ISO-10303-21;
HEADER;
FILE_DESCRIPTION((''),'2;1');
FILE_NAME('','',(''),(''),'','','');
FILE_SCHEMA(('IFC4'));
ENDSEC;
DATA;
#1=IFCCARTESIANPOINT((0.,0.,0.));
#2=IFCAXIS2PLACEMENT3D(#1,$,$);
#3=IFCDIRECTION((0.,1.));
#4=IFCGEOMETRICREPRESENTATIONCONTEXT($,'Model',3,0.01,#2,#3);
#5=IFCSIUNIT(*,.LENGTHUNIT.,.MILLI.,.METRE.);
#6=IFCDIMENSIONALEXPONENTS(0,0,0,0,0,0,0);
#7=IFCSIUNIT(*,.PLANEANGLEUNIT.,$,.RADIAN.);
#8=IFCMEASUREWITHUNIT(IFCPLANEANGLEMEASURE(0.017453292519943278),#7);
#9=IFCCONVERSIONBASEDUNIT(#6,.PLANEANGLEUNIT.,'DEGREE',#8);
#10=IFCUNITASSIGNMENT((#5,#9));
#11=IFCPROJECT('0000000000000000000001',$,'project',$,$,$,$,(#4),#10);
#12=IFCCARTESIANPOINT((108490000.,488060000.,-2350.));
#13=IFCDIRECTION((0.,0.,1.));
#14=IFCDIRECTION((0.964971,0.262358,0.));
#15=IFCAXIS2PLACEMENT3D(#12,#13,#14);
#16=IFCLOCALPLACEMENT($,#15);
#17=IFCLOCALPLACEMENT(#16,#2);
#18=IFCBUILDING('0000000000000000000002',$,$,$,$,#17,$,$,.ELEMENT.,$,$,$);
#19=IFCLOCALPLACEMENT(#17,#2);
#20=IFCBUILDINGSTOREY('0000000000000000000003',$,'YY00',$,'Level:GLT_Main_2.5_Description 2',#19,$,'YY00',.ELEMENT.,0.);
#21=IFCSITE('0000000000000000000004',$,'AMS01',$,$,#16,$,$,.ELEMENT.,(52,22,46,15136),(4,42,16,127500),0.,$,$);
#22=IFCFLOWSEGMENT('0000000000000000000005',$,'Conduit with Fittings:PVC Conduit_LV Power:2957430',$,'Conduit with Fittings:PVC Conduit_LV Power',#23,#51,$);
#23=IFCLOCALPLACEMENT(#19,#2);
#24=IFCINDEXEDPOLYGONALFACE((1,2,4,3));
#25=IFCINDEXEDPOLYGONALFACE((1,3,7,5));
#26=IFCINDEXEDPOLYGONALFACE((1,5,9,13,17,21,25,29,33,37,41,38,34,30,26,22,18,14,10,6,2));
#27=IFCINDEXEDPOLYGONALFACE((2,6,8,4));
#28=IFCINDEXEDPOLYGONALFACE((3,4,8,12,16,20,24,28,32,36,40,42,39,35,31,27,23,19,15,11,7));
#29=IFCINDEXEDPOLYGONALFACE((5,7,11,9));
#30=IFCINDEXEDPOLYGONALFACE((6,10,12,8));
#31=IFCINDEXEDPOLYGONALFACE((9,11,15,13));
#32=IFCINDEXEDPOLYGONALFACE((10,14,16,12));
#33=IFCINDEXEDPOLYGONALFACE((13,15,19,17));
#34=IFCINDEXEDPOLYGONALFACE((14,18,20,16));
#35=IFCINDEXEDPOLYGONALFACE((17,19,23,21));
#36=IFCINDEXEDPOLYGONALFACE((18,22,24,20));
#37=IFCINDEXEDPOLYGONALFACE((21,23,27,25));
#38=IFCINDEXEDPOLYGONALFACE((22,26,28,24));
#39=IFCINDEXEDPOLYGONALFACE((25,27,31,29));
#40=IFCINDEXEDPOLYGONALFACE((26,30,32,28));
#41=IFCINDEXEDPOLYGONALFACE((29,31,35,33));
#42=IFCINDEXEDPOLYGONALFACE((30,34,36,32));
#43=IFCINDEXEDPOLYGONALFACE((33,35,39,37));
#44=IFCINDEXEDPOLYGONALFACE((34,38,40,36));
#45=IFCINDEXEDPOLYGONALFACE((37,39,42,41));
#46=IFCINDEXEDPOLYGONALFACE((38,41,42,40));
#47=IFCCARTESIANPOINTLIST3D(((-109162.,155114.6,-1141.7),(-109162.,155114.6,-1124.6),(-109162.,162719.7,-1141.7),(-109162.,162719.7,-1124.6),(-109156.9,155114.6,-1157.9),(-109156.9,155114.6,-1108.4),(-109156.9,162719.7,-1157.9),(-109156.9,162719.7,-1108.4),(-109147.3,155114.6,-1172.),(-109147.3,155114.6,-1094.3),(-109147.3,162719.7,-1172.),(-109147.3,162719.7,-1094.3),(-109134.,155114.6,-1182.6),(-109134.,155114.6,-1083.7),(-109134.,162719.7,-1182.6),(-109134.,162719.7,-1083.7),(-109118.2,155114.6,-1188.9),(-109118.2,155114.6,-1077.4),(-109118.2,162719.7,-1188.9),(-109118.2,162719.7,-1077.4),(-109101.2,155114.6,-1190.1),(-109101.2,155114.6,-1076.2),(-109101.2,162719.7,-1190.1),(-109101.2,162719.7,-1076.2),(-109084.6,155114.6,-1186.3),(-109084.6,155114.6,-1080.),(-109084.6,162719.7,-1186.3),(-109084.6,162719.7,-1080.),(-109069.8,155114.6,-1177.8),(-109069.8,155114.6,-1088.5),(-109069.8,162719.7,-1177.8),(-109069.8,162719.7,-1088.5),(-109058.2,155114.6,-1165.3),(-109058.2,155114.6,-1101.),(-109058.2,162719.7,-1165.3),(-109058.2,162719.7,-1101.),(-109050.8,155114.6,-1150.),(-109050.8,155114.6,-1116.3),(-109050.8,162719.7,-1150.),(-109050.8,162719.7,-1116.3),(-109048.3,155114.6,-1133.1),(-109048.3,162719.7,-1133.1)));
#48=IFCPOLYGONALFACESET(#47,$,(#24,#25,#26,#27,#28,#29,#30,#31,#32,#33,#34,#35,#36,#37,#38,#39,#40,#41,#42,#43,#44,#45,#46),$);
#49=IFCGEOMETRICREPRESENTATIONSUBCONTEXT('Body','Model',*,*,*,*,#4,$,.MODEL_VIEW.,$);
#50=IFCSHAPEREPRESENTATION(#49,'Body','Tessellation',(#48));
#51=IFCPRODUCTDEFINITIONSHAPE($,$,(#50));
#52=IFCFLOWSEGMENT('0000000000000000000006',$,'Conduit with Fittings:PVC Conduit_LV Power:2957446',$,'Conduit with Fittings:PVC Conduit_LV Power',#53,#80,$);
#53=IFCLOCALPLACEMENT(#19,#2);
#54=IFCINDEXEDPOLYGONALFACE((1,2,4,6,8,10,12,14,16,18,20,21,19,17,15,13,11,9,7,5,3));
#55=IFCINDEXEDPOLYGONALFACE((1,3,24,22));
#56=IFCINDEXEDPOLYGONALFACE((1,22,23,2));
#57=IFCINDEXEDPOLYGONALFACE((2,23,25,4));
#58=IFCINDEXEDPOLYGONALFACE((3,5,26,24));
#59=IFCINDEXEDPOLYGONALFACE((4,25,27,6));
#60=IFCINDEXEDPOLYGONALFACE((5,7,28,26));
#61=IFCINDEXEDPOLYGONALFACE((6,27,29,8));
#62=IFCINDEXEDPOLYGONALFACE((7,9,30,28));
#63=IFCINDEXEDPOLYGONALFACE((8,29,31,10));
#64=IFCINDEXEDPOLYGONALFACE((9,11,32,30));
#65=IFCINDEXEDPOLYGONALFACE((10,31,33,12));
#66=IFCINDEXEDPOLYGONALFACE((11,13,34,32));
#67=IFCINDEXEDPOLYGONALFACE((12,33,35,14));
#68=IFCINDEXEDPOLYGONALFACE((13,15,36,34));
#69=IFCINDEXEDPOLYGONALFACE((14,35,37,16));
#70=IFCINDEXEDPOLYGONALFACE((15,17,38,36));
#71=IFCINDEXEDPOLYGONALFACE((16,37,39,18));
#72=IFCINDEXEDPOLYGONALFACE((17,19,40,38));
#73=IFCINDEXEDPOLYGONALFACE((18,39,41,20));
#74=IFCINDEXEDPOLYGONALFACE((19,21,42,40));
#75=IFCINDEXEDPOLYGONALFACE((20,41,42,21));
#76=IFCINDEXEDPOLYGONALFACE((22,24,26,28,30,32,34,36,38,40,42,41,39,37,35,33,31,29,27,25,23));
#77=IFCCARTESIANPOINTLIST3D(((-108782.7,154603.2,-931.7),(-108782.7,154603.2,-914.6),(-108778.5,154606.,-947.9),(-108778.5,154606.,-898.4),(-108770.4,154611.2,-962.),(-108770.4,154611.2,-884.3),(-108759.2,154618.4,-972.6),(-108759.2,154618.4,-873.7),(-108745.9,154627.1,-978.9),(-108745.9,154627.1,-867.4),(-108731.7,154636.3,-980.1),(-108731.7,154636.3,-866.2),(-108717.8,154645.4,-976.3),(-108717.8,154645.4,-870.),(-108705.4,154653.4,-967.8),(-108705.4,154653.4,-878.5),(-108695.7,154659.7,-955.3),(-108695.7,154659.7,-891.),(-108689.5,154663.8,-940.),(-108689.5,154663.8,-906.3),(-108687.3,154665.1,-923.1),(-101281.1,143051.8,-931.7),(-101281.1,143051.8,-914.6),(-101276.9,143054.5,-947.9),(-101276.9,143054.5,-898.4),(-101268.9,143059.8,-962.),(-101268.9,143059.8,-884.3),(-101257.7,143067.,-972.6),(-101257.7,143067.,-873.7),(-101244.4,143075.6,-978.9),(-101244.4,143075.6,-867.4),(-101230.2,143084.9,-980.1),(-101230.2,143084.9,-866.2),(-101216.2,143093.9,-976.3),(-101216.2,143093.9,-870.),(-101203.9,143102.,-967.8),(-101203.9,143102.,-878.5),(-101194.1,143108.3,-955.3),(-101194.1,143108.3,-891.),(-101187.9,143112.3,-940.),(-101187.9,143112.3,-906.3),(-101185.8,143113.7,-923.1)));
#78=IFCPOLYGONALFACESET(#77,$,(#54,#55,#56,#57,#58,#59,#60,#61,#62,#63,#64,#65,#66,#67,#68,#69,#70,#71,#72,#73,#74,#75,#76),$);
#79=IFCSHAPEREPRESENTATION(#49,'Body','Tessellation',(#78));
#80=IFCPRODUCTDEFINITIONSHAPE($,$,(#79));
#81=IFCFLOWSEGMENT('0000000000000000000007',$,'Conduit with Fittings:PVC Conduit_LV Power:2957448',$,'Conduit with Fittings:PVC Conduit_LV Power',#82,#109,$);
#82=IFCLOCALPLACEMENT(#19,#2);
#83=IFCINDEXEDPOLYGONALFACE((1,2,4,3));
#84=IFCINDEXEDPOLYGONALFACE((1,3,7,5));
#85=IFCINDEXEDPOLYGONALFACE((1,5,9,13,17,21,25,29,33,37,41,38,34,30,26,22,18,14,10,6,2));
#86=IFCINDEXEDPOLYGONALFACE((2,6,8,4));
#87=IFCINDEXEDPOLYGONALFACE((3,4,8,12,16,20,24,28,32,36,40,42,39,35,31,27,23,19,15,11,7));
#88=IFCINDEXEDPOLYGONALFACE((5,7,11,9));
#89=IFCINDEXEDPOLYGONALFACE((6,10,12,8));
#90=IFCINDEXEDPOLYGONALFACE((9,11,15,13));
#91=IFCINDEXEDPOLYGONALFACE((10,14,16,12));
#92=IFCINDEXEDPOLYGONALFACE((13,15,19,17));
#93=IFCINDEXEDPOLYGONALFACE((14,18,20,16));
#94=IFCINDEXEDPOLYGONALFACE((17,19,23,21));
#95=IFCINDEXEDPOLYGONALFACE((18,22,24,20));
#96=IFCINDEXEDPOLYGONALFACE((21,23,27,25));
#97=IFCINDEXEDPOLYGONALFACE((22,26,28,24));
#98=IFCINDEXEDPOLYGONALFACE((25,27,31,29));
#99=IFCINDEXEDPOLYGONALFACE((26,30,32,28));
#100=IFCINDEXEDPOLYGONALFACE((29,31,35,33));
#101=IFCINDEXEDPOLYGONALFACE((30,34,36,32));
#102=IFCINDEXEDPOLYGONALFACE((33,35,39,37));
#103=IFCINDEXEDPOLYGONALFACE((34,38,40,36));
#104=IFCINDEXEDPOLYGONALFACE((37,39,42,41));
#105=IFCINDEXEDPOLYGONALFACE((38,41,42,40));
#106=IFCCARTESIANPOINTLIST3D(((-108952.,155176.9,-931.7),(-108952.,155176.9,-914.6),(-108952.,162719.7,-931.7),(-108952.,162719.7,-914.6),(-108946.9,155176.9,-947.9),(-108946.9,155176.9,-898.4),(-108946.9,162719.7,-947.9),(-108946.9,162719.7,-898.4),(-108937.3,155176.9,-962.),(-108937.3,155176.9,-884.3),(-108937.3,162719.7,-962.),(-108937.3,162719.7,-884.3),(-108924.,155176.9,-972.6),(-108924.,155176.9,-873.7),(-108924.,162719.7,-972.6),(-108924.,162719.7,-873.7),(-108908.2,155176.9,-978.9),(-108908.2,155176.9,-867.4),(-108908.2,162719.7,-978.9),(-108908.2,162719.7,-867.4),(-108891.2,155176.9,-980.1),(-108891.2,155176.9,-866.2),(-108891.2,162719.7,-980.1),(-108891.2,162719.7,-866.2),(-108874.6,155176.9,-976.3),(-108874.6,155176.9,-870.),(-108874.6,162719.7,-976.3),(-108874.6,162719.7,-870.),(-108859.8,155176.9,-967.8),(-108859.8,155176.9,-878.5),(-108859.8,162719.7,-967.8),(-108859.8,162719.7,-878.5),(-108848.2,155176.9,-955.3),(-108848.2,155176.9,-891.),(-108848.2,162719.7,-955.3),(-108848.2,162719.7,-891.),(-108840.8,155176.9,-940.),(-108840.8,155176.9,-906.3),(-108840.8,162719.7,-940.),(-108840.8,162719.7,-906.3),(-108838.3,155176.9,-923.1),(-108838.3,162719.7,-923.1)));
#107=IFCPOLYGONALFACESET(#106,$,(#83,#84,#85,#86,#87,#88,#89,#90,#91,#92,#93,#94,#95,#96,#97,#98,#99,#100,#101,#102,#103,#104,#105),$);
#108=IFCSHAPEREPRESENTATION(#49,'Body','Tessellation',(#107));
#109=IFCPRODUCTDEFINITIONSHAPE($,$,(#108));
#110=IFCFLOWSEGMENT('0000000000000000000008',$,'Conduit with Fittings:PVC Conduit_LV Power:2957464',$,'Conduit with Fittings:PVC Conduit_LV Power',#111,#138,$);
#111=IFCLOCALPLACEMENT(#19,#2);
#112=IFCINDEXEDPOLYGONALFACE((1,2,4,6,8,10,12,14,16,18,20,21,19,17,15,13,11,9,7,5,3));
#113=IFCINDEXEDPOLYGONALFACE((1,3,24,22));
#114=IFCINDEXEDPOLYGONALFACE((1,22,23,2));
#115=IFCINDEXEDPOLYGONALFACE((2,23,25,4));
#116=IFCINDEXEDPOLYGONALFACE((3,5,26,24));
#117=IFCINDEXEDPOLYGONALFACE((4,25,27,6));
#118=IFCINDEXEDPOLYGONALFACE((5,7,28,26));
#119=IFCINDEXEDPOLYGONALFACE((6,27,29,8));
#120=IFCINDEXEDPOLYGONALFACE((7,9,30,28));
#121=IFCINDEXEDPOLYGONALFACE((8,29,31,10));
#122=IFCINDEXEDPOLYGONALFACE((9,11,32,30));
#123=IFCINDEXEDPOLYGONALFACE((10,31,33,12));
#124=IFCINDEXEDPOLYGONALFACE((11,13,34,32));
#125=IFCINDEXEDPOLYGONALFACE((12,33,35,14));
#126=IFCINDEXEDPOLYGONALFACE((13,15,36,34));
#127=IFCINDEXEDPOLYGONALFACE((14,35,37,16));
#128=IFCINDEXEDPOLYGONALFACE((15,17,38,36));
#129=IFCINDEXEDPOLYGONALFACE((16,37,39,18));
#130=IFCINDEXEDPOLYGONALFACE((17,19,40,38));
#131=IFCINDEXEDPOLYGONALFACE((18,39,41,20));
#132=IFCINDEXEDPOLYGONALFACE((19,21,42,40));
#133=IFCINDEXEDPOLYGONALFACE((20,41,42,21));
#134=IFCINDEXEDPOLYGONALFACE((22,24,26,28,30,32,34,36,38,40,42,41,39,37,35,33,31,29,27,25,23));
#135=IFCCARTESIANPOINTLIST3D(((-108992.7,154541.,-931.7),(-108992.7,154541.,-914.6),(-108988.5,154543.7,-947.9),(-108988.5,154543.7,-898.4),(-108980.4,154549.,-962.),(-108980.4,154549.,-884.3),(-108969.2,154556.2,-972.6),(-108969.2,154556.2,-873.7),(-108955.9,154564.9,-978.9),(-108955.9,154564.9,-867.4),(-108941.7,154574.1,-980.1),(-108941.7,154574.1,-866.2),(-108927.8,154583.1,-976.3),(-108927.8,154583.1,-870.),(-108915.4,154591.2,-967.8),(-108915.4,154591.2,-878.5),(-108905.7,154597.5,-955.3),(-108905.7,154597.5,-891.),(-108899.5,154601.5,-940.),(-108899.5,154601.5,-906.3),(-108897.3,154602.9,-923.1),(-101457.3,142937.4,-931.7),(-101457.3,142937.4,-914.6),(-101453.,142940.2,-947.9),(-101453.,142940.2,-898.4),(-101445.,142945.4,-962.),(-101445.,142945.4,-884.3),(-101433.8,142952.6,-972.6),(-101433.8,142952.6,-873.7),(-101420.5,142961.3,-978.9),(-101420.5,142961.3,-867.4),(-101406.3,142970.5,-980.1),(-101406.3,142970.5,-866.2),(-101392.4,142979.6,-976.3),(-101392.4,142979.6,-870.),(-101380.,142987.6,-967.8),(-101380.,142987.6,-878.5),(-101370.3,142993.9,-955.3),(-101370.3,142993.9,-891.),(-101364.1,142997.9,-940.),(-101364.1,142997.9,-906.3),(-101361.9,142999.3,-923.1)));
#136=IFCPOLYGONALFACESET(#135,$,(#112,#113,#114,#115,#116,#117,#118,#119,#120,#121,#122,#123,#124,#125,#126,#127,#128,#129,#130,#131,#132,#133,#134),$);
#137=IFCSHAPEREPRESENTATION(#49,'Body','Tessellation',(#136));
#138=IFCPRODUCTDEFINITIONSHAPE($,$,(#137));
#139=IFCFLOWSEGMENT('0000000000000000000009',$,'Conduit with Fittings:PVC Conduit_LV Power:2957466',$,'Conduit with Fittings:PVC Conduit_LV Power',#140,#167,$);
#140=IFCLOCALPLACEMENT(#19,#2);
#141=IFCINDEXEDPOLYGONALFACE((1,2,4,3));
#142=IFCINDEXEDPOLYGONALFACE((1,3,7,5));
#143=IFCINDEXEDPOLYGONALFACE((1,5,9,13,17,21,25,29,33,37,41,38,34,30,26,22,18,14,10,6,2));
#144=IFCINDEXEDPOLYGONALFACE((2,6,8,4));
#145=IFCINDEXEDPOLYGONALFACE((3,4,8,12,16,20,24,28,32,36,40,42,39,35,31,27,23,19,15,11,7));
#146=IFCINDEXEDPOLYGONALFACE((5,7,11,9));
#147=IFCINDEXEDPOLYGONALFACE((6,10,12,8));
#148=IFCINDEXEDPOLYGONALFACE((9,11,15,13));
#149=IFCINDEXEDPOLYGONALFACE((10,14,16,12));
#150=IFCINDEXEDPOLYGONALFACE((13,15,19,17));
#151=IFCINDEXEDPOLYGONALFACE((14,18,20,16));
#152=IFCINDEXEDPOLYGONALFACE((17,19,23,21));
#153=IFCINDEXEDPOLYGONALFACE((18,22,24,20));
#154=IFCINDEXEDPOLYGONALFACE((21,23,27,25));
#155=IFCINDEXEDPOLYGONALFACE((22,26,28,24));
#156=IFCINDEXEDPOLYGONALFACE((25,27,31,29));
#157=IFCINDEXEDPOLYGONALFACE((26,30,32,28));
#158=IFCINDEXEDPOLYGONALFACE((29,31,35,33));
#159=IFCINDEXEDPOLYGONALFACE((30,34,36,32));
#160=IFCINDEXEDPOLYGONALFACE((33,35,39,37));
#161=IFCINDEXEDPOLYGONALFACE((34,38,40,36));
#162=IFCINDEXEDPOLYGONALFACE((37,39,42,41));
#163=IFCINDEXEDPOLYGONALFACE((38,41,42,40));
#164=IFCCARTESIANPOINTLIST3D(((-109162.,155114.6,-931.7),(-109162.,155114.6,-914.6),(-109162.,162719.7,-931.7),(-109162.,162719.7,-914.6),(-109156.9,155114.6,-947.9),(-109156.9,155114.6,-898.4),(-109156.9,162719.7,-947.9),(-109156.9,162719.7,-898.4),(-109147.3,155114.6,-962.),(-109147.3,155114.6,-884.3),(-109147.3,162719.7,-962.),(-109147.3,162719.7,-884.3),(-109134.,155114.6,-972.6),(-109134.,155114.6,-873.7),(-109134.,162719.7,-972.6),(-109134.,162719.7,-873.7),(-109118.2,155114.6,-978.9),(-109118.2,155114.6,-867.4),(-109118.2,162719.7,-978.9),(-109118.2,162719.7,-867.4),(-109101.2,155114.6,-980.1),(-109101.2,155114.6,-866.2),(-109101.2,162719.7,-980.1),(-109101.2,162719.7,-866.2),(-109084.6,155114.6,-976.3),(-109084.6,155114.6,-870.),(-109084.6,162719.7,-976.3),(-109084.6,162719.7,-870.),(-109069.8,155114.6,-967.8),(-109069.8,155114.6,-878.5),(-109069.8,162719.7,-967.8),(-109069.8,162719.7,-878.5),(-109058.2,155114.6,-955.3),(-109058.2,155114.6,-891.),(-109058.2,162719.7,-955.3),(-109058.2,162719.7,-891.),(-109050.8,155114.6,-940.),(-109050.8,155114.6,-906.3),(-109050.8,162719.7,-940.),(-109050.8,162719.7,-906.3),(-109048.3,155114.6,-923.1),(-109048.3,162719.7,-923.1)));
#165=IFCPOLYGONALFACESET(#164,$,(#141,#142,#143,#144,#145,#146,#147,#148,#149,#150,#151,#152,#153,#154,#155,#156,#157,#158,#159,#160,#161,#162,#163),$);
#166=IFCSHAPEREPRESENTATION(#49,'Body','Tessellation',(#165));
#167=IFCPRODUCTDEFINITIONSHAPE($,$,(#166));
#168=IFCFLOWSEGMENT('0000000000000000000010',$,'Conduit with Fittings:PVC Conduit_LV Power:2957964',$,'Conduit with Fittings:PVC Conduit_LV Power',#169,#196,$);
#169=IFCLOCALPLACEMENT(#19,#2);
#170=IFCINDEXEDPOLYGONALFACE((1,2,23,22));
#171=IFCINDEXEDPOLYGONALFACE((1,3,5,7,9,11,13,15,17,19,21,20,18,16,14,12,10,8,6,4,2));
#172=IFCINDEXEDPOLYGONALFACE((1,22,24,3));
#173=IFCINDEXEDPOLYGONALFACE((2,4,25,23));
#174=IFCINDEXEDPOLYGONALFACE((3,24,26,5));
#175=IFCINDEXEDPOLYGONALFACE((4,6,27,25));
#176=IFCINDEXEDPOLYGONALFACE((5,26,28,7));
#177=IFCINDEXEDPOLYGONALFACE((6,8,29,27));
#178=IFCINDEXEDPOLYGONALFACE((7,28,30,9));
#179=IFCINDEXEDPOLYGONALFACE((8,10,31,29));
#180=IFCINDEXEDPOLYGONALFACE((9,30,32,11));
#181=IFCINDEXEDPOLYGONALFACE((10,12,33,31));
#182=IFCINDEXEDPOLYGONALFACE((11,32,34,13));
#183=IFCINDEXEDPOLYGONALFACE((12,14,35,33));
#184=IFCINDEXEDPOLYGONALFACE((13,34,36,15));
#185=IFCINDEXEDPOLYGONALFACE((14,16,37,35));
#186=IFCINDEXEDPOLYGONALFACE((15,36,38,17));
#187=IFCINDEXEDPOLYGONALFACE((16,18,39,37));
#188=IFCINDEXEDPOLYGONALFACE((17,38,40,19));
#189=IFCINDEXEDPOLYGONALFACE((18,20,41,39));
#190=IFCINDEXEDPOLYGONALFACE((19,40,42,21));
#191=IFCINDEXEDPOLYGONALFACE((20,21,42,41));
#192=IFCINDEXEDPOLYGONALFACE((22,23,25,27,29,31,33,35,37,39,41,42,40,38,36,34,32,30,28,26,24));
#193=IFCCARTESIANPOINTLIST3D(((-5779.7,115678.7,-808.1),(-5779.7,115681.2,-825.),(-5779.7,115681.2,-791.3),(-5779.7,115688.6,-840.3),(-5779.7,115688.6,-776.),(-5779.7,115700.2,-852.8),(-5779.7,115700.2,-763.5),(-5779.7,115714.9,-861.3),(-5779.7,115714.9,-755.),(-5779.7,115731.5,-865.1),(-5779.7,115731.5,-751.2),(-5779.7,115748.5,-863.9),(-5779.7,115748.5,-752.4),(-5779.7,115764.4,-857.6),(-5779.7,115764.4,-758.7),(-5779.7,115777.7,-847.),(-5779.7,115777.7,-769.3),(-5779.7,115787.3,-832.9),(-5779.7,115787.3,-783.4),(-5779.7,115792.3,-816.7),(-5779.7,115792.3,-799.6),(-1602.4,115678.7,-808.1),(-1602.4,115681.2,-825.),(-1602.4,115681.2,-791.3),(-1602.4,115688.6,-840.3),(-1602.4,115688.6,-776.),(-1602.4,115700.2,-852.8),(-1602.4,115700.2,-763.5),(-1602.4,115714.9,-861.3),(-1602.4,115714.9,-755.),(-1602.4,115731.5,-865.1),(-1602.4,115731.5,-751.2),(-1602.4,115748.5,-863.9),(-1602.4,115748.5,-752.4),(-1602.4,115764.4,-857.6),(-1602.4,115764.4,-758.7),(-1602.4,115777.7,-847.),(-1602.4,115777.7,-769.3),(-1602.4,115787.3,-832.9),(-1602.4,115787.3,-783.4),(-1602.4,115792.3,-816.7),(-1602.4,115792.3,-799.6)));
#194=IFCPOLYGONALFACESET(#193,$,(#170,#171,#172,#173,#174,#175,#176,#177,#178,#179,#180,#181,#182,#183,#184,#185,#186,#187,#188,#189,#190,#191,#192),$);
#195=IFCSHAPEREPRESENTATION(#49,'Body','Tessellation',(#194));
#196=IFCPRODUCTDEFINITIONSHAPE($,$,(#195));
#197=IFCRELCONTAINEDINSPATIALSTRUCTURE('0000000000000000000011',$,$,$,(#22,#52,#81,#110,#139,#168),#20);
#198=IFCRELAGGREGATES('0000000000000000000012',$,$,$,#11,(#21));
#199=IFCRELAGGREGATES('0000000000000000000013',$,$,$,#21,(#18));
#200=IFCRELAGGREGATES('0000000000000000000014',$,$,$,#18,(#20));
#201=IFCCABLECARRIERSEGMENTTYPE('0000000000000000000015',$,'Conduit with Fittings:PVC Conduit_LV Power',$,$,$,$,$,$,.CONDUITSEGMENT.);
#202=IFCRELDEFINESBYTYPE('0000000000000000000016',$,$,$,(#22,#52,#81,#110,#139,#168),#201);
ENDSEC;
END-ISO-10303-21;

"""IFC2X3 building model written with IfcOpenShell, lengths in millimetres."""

from ifc_helpers import new_model, entity, si_unit, converted_unit, direction, frame, frame_2d, origin, origin_2d_with_axis, place, context, subcontext, project, spatial, circle, extrude, type_object, element, save


model = new_model("IFC2X3")

# Units and contexts
model_context = context("Model", 3, precision=0.01, world=origin(), true_north=direction((0.0, 1.0)))
body_context = subcontext(model_context, "Body", "Model", "MODEL_VIEW")
ifc_project = project(units=[si_unit("LENGTHUNIT", "METRE", prefix="MILLI"), converted_unit("PLANEANGLEUNIT", "DEGREE", entity("IfcPlaneAngleMeasure", 0.017453292519943278), si_unit("PLANEANGLEUNIT", "RADIAN"), dimensions=[0, 0, 0, 0, 0, 0, 0])], contexts=[model_context])

# Site, building, storey
site_placement = place(None, frame((108490000.0, 488060000.0, -2350.0), z_axis=(0.0, 0.0, 1.0), x_axis=(0.964971, 0.262358, 0.0)))
site = spatial("IfcSite", under=ifc_project, at=site_placement, Name="AMS01", CompositionType="ELEMENT", RefLatitude=(52, 22, 46, 15136), RefLongitude=(4, 42, 16, 127500), RefElevation=0.0)
building_placement = place(site_placement, origin())
building = spatial("IfcBuilding", under=site, at=building_placement, CompositionType="ELEMENT")
storey_placement = place(building_placement, origin())
storey = spatial("IfcBuildingStorey", under=building, at=storey_placement, Name="YY00", ObjectType="Level:GLT_Main_2.5_Description 2", LongName="YY00", CompositionType="ELEMENT", Elevation=0.0)

# Flow segments
cable_carrier_segment_type = type_object("IfcCableCarrierSegmentType", Name="Conduit with Fittings:PVC Conduit_LV Power", PredefinedType="CONDUITSEGMENT")
flow_segment_1_placement = place(storey_placement, origin())
element("IfcFlowSegment", 1, at=flow_segment_1_placement, inside=storey, type_object=cable_carrier_segment_type, Name="Conduit with Fittings:PVC Conduit_LV Power:2957430", ObjectType="Conduit with Fittings:PVC Conduit_LV Power", context=body_context, shape_type="SweptSolid", body=[
    extrude(circle(Radius=57.2, at=origin_2d_with_axis()), frame((-109105.4, 155114.6, -1133.1), z_axis=(0.0, 1.0, 0.0), x_axis=(1.0, 0.0, 0.0)), (0.0, 0.0, 1.0), 7605.1),
])
flow_segment_2_placement = place(storey_placement, origin())
element("IfcFlowSegment", 2, at=flow_segment_2_placement, inside=storey, type_object=cable_carrier_segment_type, Name="Conduit with Fittings:PVC Conduit_LV Power:2957446", ObjectType="Conduit with Fittings:PVC Conduit_LV Power", context=body_context, shape_type="SweptSolid", body=[
    extrude(circle(Radius=57.2, at=origin_2d_with_axis()), frame((-101233.7, 143082.6, -923.1), z_axis=(-0.544636, 0.838673, 0.0), x_axis=(0.838673, 0.544636, 0.0)), (0.0, 0.0, 1.0), 13773.5),
])
flow_segment_3_placement = place(storey_placement, origin())
element("IfcFlowSegment", 3, at=flow_segment_3_placement, inside=storey, type_object=cable_carrier_segment_type, Name="Conduit with Fittings:PVC Conduit_LV Power:2957448", ObjectType="Conduit with Fittings:PVC Conduit_LV Power", context=body_context, shape_type="SweptSolid", body=[
    extrude(circle(Radius=57.2, at=origin_2d_with_axis()), frame((-108895.4, 155176.9, -923.1), z_axis=(0.0, 1.0, 0.0), x_axis=(1.0, 0.0, 0.0)), (0.0, 0.0, 1.0), 7542.8),
])
flow_segment_4_placement = place(storey_placement, origin())
element("IfcFlowSegment", 4, at=flow_segment_4_placement, inside=storey, type_object=cable_carrier_segment_type, Name="Conduit with Fittings:PVC Conduit_LV Power:2957464", ObjectType="Conduit with Fittings:PVC Conduit_LV Power", context=body_context, shape_type="SweptSolid", body=[
    extrude(circle(Radius=57.2, at=frame_2d((0.0, 0.0), x_axis=(1.0, 0.0))), frame((-108945.3, 154571.8, -923.1), z_axis=(0.544637, -0.838672, 0.0), x_axis=(0.838672, 0.544637, 0.0)), (0.0, 0.0, 1.0), 13835.7),
])
flow_segment_5_placement = place(storey_placement, origin())
element("IfcFlowSegment", 5, at=flow_segment_5_placement, inside=storey, type_object=cable_carrier_segment_type, Name="Conduit with Fittings:PVC Conduit_LV Power:2957466", ObjectType="Conduit with Fittings:PVC Conduit_LV Power", context=body_context, shape_type="SweptSolid", body=[
    extrude(circle(Radius=57.2, at=origin_2d_with_axis()), frame((-109105.4, 155114.6, -923.1), z_axis=(0.0, 1.0, 0.0), x_axis=(1.0, 0.0, 0.0)), (0.0, 0.0, 1.0), 7605.1),
])
flow_segment_6_placement = place(storey_placement, origin())
element("IfcFlowSegment", 6, at=flow_segment_6_placement, inside=storey, type_object=cable_carrier_segment_type, Name="Conduit with Fittings:PVC Conduit_LV Power:2957964", ObjectType="Conduit with Fittings:PVC Conduit_LV Power", context=body_context, shape_type="SweptSolid", body=[
    extrude(circle(Radius=57.2, at=frame_2d((0.0, 0.0), x_axis=(1.0, 0.0))), frame((-5779.7, 115735.8, -808.1), z_axis=(1.0, 0.0, 0.0), x_axis=(0.0, -1.0, 0.0)), (0.0, 0.0, 1.0), 4177.3),
])

save(model, "model.ifc")
